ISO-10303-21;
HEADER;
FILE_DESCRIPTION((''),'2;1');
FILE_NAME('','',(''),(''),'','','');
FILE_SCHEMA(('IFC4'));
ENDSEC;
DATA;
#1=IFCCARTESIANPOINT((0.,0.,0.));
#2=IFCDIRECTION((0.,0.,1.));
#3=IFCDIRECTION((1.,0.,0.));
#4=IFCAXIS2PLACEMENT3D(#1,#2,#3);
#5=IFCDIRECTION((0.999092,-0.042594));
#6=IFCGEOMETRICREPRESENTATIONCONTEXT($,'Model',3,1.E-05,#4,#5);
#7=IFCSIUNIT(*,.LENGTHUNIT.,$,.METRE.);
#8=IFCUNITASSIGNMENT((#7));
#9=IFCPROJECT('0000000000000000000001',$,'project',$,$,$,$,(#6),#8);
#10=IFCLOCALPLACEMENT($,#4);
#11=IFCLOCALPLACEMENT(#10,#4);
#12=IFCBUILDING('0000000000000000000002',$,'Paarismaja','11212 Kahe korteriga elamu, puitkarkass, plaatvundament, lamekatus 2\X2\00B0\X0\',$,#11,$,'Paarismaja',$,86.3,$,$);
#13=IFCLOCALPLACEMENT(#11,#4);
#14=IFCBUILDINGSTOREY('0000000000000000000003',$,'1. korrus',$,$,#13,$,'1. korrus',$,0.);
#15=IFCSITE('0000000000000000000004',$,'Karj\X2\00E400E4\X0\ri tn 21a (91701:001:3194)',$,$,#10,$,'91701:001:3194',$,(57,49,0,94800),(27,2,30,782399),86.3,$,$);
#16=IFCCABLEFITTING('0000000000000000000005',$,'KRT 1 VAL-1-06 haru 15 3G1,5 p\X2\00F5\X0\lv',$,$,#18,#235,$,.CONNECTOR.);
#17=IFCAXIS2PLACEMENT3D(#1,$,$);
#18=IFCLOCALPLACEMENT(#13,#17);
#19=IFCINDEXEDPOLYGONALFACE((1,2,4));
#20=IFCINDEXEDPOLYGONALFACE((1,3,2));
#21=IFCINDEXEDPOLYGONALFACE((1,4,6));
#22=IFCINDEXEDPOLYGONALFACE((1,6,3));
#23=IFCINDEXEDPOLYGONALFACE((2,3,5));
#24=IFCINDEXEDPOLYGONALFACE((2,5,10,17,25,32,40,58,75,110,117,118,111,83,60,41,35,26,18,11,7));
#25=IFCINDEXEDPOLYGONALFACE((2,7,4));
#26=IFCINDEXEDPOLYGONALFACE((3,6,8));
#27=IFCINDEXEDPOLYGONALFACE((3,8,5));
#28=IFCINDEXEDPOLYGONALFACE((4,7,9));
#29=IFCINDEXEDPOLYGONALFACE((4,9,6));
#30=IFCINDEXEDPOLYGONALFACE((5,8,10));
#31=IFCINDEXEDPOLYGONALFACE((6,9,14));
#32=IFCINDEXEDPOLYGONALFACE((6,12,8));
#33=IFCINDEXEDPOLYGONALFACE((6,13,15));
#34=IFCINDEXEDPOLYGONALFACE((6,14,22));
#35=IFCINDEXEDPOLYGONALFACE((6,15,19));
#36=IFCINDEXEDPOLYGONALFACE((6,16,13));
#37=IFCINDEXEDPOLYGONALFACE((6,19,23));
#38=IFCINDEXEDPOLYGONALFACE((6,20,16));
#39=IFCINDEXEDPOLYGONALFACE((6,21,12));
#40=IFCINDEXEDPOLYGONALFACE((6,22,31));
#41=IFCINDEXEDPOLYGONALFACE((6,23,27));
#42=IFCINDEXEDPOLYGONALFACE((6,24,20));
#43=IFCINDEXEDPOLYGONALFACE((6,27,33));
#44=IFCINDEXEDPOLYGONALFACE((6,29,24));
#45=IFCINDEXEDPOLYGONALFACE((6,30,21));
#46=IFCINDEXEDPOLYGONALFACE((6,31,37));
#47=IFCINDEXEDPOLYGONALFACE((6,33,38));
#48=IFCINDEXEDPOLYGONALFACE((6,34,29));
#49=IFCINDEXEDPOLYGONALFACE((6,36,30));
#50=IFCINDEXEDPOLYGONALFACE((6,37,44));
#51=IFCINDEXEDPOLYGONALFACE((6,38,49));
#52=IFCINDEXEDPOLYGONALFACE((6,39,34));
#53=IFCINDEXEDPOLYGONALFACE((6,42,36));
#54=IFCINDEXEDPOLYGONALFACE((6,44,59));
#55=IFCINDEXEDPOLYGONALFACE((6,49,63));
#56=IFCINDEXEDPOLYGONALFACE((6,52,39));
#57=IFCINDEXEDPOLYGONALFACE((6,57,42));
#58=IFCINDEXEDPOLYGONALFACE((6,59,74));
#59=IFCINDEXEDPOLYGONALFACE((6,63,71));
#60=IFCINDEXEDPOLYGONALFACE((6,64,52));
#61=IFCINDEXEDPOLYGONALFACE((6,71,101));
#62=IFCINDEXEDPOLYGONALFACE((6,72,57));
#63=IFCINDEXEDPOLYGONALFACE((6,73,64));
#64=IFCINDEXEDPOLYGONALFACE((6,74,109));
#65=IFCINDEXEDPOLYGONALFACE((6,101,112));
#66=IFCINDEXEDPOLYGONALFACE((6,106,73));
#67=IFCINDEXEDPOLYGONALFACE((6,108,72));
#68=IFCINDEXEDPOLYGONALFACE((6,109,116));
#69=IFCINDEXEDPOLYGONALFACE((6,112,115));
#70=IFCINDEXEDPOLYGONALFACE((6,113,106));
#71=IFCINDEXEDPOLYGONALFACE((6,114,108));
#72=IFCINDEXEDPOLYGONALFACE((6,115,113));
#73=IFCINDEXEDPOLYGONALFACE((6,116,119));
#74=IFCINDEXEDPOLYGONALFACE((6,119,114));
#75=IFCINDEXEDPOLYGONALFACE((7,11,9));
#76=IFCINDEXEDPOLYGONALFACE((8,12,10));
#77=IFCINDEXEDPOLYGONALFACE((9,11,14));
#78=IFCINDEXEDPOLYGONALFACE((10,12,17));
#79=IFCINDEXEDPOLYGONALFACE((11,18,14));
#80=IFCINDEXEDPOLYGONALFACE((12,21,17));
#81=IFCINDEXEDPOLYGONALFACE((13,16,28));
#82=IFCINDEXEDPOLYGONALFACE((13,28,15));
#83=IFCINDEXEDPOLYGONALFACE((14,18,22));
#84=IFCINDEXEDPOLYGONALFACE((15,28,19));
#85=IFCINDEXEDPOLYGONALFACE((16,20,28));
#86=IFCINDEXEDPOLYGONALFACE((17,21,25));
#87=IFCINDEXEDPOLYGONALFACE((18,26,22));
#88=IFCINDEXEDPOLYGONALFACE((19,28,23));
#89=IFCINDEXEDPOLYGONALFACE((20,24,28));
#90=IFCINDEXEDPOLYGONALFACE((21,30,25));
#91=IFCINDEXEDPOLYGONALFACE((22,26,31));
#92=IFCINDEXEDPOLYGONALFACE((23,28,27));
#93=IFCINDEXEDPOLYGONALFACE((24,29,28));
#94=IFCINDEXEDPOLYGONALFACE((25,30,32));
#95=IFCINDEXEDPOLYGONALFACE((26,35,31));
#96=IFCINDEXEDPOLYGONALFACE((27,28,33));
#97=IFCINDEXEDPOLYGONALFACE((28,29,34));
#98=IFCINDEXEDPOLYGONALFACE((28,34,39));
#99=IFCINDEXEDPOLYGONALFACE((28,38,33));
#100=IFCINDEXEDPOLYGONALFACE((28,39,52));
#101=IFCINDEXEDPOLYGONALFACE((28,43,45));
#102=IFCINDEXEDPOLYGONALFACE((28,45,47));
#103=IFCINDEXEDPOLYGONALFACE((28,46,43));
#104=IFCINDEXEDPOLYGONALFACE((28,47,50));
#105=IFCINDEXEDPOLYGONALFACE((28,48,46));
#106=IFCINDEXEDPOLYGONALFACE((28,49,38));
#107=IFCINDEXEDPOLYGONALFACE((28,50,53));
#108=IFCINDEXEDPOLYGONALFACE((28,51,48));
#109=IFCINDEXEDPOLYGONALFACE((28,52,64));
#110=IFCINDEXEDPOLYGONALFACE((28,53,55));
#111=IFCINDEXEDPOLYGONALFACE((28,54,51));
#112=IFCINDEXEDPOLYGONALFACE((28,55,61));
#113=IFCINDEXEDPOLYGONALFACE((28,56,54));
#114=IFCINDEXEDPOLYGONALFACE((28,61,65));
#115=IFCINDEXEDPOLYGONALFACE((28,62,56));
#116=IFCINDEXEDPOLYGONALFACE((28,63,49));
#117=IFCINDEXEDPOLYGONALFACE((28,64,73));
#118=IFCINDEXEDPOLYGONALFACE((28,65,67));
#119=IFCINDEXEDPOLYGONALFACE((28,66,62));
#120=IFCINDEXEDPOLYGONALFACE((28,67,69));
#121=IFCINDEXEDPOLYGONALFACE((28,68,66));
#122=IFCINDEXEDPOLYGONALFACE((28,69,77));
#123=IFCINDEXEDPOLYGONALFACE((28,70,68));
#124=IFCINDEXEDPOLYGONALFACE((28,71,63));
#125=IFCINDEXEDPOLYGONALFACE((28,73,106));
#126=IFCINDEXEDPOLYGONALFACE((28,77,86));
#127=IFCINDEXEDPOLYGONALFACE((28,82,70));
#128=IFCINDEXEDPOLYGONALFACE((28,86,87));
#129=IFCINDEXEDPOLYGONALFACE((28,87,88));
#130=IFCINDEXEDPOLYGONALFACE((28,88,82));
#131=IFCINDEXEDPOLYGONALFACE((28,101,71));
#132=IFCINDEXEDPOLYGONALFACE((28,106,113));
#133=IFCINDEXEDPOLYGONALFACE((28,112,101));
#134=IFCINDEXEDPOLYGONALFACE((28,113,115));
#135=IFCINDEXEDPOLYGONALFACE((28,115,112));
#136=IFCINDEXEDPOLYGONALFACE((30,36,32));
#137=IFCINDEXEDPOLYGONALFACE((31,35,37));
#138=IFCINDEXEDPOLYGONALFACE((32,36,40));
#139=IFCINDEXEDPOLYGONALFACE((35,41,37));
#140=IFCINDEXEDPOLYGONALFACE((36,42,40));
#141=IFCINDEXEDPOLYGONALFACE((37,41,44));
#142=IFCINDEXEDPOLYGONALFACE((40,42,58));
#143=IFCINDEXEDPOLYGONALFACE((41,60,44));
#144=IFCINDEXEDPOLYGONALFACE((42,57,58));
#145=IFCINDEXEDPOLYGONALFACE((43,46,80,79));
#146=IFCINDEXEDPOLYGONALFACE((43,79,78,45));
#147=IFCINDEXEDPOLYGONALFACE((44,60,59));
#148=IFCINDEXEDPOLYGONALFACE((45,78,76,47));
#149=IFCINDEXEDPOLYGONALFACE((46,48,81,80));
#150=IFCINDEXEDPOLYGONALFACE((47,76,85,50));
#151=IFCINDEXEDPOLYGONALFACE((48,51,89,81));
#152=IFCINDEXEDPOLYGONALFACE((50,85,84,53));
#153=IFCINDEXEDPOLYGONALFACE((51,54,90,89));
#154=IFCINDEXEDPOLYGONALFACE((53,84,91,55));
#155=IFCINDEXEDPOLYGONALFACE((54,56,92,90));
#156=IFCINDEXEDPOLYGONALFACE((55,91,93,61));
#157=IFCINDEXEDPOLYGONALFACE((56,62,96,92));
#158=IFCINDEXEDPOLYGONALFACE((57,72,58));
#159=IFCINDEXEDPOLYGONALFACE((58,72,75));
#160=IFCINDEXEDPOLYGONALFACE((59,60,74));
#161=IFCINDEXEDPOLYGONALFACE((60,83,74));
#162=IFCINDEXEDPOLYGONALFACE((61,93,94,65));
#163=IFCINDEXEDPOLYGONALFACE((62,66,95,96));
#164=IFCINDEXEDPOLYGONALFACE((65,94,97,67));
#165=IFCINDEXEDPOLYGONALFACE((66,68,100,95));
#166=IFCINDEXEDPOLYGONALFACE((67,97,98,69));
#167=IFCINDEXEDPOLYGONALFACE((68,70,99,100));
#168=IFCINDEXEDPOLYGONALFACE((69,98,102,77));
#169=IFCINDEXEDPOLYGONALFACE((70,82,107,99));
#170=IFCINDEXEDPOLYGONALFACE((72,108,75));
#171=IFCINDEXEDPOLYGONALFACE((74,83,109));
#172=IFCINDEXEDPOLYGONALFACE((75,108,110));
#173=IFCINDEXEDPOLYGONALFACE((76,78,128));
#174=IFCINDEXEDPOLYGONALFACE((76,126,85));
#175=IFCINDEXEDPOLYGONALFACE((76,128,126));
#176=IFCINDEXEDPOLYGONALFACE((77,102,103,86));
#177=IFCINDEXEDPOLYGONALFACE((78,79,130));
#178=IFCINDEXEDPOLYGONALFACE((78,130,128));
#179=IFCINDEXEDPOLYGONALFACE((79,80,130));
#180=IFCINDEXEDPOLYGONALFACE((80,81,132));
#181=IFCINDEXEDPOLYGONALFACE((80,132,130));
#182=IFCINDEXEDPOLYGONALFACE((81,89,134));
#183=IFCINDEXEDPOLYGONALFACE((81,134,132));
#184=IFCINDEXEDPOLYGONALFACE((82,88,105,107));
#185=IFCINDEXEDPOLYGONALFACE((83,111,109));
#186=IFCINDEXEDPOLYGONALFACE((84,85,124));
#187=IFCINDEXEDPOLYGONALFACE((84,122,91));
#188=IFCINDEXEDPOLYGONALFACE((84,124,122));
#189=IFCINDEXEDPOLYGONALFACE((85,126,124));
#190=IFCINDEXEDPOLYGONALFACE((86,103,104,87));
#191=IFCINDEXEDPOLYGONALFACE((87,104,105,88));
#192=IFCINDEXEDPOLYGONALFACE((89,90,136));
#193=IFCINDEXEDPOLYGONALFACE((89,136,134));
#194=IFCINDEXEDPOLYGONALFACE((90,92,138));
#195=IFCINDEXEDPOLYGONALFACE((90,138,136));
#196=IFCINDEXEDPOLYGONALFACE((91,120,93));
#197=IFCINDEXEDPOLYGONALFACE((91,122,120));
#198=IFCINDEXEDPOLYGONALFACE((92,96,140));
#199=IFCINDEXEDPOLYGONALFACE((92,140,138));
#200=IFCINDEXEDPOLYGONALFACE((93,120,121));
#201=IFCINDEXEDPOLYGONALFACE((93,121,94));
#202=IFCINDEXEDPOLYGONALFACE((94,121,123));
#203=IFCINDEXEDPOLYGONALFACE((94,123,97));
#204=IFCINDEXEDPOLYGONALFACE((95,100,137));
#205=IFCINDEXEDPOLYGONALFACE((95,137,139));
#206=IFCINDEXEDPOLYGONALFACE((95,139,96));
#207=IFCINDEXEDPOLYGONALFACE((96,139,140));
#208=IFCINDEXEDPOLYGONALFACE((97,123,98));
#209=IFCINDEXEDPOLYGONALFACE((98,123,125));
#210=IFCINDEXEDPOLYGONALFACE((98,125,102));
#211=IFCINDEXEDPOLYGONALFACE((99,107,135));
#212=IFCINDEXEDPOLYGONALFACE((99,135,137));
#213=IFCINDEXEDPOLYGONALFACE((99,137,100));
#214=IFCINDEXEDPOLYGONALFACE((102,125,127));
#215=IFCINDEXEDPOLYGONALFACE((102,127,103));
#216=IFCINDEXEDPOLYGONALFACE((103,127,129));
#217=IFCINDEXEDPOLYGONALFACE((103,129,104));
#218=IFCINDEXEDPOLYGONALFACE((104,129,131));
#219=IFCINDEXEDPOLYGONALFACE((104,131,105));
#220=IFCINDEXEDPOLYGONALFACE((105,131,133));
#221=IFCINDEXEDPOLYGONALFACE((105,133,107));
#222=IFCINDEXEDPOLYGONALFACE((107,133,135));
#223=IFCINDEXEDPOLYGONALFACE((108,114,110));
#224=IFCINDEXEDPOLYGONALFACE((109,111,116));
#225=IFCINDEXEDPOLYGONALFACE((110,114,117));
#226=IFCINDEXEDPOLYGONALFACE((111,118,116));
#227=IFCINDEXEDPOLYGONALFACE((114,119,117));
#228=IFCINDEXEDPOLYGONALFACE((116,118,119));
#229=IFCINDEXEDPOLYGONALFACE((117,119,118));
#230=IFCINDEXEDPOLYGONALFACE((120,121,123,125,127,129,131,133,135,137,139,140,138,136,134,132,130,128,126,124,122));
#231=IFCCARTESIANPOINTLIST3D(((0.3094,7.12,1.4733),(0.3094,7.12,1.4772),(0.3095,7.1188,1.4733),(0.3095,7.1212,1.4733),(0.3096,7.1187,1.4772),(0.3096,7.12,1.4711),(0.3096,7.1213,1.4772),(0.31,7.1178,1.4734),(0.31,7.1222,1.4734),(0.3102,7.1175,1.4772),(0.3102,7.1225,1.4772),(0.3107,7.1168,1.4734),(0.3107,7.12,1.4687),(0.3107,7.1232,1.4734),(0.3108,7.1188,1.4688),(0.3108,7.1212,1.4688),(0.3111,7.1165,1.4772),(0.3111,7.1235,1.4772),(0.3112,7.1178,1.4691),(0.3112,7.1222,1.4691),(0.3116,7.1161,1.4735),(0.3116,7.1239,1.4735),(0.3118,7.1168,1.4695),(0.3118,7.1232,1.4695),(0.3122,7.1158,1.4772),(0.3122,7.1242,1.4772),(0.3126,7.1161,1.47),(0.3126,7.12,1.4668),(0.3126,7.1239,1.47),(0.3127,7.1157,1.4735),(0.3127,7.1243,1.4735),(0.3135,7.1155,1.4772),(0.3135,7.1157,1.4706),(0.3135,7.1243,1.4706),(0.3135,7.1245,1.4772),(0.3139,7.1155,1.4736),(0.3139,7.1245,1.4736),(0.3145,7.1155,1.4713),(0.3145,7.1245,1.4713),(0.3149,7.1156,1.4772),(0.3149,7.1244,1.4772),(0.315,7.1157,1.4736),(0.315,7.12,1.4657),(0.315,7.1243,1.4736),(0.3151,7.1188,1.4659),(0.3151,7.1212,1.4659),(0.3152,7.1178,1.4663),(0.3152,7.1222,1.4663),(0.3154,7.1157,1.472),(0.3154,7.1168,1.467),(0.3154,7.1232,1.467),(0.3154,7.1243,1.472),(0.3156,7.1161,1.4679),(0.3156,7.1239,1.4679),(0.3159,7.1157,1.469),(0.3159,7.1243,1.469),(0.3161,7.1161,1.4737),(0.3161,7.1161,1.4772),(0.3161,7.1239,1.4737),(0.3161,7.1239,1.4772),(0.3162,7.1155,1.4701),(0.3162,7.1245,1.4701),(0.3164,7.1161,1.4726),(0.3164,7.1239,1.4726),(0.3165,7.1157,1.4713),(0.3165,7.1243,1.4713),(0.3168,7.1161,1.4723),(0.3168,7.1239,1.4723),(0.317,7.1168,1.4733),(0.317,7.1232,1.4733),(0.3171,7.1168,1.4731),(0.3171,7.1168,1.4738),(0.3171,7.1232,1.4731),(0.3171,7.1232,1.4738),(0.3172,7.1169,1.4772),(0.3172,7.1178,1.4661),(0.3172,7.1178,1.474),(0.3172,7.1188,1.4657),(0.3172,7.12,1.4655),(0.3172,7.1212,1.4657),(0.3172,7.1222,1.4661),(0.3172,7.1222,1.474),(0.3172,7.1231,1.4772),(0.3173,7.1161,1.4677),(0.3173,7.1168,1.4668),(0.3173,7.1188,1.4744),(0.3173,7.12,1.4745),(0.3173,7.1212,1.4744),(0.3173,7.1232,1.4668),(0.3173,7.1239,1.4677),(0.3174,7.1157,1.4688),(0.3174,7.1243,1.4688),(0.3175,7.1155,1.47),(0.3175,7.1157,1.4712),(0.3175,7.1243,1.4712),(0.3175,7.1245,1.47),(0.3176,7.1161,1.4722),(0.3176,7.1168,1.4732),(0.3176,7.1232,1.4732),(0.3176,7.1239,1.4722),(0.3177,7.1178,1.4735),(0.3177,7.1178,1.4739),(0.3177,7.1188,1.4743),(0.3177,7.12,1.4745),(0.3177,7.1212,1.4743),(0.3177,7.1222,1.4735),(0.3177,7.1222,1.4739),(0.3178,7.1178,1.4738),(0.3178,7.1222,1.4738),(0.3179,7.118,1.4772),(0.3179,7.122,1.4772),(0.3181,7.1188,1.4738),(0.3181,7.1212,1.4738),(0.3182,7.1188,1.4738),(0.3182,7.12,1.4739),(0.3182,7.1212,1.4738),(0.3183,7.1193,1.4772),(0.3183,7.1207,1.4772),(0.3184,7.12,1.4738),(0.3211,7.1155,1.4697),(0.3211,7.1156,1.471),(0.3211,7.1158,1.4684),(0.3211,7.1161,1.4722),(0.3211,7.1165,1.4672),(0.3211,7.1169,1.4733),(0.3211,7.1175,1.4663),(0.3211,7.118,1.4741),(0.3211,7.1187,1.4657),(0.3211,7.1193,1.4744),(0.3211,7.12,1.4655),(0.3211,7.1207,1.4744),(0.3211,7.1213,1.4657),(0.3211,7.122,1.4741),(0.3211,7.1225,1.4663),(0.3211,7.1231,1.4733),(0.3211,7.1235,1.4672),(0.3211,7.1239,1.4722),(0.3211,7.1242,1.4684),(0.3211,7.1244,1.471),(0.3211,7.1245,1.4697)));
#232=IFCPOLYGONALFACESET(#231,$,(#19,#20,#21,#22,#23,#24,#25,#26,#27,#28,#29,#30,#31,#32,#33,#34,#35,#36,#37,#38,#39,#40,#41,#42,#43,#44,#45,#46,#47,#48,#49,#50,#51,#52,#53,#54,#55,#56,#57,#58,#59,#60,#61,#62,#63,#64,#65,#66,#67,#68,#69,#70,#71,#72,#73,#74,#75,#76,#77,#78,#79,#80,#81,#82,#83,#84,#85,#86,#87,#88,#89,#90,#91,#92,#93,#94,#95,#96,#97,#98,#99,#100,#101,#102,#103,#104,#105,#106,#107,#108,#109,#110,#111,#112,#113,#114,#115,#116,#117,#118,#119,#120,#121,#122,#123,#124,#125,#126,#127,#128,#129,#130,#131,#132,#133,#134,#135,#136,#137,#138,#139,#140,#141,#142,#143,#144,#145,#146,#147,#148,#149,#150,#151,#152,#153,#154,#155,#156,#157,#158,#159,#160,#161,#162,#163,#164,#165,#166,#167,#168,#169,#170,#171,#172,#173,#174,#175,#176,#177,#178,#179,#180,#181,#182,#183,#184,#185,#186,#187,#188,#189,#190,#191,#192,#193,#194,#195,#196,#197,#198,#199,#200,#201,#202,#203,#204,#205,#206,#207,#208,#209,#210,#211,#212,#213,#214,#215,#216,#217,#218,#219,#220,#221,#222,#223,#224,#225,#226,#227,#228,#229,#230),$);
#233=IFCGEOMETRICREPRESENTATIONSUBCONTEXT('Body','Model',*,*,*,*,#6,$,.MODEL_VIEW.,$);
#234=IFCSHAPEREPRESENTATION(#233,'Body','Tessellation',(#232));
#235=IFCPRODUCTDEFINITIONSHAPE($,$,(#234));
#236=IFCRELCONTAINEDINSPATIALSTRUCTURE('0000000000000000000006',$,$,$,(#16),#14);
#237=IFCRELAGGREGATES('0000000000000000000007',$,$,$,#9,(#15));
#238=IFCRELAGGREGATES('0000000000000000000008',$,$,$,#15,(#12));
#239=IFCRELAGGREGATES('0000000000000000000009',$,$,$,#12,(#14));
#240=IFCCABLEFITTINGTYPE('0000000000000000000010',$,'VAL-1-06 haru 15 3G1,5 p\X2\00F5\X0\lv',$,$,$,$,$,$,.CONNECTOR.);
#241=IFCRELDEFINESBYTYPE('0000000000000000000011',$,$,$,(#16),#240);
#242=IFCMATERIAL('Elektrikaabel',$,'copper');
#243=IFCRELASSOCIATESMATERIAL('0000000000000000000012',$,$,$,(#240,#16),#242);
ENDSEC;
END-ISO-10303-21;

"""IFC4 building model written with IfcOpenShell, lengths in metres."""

from ifc_helpers import new_model, entity, si_unit, direction, frame, origin_with_axes, place, context, subcontext, project, spatial, material, type_object, element, save


model = new_model("IFC4")

# Units and contexts
model_context = context("Model", 3, precision=1e-05, world=origin_with_axes(), true_north=direction((0.999092, -0.042594)))
body_context = subcontext(model_context, "Body", "Model", "MODEL_VIEW")
ifc_project = project(units=[si_unit("LENGTHUNIT", "METRE")], contexts=[model_context])

# Site, building, storey
site_placement = place(None, origin_with_axes())
site = spatial("IfcSite", under=ifc_project, at=site_placement, Name="Karjääri tn 21a (91701:001:3194)", LongName="91701:001:3194", RefLatitude=(57, 49, 0, 94800), RefLongitude=(27, 2, 30, 782399), RefElevation=86.3)
building_placement = place(site_placement, origin_with_axes())
building = spatial("IfcBuilding", under=site, at=building_placement, Name="Paarismaja", Description="11212 Kahe korteriga elamu, puitkarkass, plaatvundament, lamekatus 2°", LongName="Paarismaja", ElevationOfRefHeight=86.3)
storey_placement = place(building_placement, origin_with_axes())
storey = spatial("IfcBuildingStorey", under=building, at=storey_placement, Name="1. korrus", LongName="1. korrus", Elevation=0.0)

# Cable fitting
ifc_material_1 = material(Name="Elektrikaabel", Category="copper")
cable_fitting_type_1 = type_object("IfcCableFittingType", Name="VAL-1-06 haru 15 3G1,5 põlv", PredefinedType="CONNECTOR", material=ifc_material_1)
cable_fitting_1_placement = place(storey_placement, frame((0.3139, 7.12, 1.47), z_axis=(0.0, 0.0, 1.0), x_axis=(1.0, 0.0, 0.0)))
element("IfcCableFitting", 1, at=cable_fitting_1_placement, inside=storey, type_object=cable_fitting_type_1, material=ifc_material_1, Name="KRT 1 VAL-1-06 haru 15 3G1,5 põlv", PredefinedType="CONNECTOR", context=body_context, shape_type="AdvancedSweptSolid", body=[
    entity("IfcSweptDiskSolid", entity("IfcIndexedPolyCurve", entity("IfcCartesianPointList3D", [[0.0072, 0.0, 0.0], [0.0036, 0.0, 0.0], [0.0023, 0.0, 0.0001], [0.0013, 0.0, 0.0006], [0.0006, 0.0, 0.0013], [0.0001, 0.0, 0.0023], [0.0, 0.0, 0.0036], [0.0, 0.0, 0.0072]]), None, False), 0.0045),
])

save(model, "model.ifc")
